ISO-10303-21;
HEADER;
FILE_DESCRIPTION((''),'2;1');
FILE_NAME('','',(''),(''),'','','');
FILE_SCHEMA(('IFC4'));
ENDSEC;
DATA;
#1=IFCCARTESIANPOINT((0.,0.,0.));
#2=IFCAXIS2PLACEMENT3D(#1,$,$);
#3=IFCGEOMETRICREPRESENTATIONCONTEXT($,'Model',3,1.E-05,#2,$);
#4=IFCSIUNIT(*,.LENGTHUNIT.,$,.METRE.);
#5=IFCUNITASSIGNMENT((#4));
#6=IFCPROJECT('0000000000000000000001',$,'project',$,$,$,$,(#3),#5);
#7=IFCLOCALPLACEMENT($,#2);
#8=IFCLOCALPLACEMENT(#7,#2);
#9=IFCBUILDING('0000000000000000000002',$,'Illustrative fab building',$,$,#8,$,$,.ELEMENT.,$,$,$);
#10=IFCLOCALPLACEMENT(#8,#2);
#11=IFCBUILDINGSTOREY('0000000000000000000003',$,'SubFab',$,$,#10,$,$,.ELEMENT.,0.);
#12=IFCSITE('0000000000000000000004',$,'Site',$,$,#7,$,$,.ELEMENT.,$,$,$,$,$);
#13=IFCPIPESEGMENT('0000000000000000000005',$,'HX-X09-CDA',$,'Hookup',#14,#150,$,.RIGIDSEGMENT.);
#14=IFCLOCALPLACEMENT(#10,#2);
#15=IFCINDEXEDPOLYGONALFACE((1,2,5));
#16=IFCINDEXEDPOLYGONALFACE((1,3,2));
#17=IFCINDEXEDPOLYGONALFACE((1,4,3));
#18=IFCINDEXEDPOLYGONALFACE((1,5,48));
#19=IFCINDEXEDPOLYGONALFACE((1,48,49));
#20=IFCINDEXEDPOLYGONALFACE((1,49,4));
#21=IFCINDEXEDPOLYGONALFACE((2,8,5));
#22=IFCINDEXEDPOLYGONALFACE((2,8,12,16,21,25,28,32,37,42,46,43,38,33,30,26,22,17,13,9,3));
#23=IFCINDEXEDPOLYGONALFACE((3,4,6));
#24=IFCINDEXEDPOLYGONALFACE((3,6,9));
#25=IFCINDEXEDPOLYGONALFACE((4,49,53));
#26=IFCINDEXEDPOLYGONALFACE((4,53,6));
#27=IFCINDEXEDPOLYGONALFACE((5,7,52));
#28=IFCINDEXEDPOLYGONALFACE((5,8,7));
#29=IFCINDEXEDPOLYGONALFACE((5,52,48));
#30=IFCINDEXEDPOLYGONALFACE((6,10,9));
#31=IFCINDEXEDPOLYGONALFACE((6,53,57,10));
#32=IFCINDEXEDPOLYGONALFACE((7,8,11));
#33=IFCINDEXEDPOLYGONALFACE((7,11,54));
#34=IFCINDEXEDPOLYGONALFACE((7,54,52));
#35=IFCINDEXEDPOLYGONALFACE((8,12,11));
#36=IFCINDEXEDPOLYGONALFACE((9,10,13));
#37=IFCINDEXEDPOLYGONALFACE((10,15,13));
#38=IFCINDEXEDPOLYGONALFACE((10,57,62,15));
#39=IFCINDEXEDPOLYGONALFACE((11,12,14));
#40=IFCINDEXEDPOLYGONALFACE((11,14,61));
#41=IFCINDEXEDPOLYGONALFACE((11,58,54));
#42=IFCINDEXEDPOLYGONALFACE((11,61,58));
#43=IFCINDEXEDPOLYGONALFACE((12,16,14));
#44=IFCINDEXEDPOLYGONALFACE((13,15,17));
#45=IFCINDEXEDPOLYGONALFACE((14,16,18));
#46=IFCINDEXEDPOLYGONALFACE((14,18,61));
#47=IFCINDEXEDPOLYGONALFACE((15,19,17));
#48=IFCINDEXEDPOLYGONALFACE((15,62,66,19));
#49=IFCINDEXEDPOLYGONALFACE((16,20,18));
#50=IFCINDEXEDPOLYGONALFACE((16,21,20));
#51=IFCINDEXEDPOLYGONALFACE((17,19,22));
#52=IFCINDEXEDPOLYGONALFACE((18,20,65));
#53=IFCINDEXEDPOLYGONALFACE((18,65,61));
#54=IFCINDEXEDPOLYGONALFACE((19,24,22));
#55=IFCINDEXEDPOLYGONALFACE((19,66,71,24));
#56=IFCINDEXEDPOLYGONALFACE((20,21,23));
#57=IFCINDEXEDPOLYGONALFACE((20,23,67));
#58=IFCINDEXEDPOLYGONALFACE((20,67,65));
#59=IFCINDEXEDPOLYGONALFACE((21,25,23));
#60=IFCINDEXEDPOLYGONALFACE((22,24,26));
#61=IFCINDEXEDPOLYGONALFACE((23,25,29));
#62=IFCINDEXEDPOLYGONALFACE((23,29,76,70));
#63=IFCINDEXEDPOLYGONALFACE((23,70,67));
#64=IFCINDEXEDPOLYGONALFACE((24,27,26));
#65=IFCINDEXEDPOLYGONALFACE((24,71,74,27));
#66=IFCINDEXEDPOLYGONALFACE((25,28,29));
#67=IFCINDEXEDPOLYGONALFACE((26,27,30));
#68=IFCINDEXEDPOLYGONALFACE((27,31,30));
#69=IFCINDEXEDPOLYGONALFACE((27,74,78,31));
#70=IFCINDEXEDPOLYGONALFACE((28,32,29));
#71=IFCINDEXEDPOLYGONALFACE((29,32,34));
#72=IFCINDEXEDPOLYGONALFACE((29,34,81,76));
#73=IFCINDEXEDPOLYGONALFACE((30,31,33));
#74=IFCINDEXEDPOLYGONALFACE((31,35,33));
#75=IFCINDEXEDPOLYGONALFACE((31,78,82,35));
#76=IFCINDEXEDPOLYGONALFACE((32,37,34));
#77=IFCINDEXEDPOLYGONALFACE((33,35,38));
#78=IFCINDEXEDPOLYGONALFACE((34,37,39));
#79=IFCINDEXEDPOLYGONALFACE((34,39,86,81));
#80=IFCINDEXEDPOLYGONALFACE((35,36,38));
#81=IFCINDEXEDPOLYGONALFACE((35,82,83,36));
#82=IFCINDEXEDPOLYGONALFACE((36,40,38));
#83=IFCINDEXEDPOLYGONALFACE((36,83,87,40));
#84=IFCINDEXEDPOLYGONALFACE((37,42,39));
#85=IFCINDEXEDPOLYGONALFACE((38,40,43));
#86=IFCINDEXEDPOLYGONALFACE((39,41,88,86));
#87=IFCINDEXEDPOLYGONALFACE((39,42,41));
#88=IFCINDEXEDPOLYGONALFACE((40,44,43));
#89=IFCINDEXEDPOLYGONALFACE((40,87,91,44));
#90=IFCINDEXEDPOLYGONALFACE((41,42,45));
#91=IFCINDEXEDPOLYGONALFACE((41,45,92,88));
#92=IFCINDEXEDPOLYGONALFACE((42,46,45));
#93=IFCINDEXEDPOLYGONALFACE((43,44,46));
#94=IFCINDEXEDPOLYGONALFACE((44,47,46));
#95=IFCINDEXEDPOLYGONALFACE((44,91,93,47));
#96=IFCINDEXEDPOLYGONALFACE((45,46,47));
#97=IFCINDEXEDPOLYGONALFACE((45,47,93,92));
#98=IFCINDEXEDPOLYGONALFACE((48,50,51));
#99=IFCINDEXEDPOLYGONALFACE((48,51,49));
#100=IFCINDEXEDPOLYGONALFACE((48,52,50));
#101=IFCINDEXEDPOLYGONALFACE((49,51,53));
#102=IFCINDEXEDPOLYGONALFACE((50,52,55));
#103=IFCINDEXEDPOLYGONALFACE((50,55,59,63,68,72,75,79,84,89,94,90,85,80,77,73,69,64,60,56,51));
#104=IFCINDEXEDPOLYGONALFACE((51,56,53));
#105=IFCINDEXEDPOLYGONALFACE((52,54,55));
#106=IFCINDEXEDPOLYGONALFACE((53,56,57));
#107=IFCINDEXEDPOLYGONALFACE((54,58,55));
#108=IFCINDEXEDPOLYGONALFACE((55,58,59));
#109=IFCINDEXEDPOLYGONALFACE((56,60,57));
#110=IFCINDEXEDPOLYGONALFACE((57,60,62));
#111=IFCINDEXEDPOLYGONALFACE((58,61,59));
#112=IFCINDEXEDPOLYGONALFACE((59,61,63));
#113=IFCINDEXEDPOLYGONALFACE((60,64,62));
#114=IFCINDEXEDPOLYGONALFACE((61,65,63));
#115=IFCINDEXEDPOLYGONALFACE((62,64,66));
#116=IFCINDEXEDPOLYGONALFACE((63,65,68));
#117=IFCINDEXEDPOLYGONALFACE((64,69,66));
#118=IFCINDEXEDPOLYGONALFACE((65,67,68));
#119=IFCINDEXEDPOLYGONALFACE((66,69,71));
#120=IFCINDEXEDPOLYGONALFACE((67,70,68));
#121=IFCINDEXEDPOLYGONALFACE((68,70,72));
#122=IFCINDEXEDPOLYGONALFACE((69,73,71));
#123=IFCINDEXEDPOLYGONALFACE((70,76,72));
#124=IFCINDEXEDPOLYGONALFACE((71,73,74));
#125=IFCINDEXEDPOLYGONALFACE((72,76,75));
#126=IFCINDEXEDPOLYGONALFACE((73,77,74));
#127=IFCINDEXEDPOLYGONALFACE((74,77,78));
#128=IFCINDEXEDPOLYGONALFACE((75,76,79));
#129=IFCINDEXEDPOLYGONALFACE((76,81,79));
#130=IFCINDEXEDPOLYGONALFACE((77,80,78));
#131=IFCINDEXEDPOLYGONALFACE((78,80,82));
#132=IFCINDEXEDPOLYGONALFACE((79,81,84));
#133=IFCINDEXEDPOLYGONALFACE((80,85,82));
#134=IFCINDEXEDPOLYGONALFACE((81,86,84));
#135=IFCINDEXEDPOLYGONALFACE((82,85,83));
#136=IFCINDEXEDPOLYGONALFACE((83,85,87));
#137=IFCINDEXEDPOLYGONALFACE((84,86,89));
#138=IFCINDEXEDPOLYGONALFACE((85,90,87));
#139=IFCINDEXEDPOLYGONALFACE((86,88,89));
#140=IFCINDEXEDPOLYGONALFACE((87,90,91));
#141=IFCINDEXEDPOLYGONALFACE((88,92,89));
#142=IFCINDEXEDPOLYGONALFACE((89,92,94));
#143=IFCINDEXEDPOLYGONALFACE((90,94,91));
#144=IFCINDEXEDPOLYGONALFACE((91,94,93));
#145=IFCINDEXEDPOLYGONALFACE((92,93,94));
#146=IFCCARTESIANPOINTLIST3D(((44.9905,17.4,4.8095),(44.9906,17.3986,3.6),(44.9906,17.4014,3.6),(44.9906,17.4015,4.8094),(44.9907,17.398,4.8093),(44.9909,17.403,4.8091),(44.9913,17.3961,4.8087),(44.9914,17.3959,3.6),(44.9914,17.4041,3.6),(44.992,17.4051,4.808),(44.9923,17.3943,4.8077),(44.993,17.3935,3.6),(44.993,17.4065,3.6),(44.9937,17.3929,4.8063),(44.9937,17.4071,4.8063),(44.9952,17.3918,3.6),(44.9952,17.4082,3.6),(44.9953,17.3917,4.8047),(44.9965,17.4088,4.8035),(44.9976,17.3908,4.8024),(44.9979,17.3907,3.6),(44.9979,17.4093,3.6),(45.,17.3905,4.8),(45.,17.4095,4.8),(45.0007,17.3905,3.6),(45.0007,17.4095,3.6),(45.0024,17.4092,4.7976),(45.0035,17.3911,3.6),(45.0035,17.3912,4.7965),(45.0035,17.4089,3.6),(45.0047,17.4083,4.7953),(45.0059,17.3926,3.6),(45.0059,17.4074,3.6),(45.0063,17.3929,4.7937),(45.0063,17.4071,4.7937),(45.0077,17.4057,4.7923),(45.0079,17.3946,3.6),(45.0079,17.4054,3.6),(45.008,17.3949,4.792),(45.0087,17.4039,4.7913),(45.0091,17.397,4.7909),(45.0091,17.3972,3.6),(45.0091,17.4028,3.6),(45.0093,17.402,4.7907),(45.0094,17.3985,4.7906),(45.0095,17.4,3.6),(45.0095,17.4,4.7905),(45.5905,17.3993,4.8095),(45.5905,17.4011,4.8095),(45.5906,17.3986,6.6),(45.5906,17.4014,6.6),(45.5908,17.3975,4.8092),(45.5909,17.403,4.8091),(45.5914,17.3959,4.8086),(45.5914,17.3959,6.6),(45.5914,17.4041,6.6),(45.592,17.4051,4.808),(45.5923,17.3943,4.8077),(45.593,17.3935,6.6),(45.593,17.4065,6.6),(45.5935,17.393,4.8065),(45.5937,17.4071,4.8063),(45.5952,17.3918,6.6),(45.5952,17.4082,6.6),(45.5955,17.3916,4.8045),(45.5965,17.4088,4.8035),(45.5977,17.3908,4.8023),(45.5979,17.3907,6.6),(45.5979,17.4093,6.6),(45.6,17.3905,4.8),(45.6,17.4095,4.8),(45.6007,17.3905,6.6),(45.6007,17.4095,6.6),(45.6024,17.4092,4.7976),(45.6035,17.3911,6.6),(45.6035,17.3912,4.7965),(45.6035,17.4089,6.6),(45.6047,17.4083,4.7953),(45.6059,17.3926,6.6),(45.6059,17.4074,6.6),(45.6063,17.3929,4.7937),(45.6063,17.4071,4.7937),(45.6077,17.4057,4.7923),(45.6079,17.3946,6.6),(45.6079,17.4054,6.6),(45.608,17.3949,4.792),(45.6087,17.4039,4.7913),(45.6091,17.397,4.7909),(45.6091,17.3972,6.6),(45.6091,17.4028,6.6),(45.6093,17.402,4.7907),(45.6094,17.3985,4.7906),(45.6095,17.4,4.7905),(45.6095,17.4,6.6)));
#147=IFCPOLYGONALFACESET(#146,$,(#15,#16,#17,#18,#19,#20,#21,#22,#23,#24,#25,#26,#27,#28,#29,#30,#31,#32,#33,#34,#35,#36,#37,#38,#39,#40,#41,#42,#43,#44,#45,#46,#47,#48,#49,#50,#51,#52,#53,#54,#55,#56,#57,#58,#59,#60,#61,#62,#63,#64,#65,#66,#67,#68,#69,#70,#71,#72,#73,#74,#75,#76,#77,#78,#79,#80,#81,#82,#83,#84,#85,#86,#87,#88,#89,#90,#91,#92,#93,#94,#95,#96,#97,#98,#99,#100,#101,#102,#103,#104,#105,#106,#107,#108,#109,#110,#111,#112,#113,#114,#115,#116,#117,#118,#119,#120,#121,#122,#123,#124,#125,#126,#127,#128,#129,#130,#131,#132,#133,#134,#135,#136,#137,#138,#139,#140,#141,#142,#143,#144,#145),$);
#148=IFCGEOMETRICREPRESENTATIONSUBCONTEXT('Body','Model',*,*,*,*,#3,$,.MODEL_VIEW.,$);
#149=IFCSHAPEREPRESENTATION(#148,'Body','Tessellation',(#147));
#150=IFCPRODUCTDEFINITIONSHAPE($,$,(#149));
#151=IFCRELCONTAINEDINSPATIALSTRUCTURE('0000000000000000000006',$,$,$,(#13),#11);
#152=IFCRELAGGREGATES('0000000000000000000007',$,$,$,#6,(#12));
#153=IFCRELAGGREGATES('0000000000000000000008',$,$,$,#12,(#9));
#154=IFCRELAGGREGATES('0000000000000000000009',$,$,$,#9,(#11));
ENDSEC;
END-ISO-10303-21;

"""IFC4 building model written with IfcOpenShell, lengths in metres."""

from ifc_helpers import new_model, entity, si_unit, origin, place, context, subcontext, project, spatial, element, save


model = new_model("IFC4")

# Units and contexts
model_context = context("Model", 3, precision=1e-05, world=origin())
body_context = subcontext(model_context, "Body", "Model", "MODEL_VIEW")
ifc_project = project(units=[si_unit("LENGTHUNIT", "METRE")], contexts=[model_context])

# Site, building, storey
site_placement = place(None, origin())
site = spatial("IfcSite", under=ifc_project, at=site_placement, Name="Site", CompositionType="ELEMENT")
building_placement = place(site_placement, origin())
building = spatial("IfcBuilding", under=site, at=building_placement, Name="Illustrative fab building", CompositionType="ELEMENT")
storey_placement = place(building_placement, origin())
storey = spatial("IfcBuildingStorey", under=building, at=storey_placement, Name="SubFab", CompositionType="ELEMENT", Elevation=0.0)

# Pipe segment
pipe_segment_1_placement = place(storey_placement, origin())
element("IfcPipeSegment", 1, at=pipe_segment_1_placement, inside=storey, Name="HX-X09-CDA", ObjectType="Hookup", PredefinedType="RIGIDSEGMENT", context=body_context, shape_type="AdvancedSweptSolid", body=[
    entity("IfcSweptDiskSolid", entity("IfcPolyline", [entity("IfcCartesianPoint", [45.0, 17.4, 3.6]), entity("IfcCartesianPoint", [45.0, 17.4, 4.8]), entity("IfcCartesianPoint", [45.6, 17.4, 4.8]), entity("IfcCartesianPoint", [45.6, 17.4, 6.6])]), 0.0095),
])

save(model, "model.ifc")
